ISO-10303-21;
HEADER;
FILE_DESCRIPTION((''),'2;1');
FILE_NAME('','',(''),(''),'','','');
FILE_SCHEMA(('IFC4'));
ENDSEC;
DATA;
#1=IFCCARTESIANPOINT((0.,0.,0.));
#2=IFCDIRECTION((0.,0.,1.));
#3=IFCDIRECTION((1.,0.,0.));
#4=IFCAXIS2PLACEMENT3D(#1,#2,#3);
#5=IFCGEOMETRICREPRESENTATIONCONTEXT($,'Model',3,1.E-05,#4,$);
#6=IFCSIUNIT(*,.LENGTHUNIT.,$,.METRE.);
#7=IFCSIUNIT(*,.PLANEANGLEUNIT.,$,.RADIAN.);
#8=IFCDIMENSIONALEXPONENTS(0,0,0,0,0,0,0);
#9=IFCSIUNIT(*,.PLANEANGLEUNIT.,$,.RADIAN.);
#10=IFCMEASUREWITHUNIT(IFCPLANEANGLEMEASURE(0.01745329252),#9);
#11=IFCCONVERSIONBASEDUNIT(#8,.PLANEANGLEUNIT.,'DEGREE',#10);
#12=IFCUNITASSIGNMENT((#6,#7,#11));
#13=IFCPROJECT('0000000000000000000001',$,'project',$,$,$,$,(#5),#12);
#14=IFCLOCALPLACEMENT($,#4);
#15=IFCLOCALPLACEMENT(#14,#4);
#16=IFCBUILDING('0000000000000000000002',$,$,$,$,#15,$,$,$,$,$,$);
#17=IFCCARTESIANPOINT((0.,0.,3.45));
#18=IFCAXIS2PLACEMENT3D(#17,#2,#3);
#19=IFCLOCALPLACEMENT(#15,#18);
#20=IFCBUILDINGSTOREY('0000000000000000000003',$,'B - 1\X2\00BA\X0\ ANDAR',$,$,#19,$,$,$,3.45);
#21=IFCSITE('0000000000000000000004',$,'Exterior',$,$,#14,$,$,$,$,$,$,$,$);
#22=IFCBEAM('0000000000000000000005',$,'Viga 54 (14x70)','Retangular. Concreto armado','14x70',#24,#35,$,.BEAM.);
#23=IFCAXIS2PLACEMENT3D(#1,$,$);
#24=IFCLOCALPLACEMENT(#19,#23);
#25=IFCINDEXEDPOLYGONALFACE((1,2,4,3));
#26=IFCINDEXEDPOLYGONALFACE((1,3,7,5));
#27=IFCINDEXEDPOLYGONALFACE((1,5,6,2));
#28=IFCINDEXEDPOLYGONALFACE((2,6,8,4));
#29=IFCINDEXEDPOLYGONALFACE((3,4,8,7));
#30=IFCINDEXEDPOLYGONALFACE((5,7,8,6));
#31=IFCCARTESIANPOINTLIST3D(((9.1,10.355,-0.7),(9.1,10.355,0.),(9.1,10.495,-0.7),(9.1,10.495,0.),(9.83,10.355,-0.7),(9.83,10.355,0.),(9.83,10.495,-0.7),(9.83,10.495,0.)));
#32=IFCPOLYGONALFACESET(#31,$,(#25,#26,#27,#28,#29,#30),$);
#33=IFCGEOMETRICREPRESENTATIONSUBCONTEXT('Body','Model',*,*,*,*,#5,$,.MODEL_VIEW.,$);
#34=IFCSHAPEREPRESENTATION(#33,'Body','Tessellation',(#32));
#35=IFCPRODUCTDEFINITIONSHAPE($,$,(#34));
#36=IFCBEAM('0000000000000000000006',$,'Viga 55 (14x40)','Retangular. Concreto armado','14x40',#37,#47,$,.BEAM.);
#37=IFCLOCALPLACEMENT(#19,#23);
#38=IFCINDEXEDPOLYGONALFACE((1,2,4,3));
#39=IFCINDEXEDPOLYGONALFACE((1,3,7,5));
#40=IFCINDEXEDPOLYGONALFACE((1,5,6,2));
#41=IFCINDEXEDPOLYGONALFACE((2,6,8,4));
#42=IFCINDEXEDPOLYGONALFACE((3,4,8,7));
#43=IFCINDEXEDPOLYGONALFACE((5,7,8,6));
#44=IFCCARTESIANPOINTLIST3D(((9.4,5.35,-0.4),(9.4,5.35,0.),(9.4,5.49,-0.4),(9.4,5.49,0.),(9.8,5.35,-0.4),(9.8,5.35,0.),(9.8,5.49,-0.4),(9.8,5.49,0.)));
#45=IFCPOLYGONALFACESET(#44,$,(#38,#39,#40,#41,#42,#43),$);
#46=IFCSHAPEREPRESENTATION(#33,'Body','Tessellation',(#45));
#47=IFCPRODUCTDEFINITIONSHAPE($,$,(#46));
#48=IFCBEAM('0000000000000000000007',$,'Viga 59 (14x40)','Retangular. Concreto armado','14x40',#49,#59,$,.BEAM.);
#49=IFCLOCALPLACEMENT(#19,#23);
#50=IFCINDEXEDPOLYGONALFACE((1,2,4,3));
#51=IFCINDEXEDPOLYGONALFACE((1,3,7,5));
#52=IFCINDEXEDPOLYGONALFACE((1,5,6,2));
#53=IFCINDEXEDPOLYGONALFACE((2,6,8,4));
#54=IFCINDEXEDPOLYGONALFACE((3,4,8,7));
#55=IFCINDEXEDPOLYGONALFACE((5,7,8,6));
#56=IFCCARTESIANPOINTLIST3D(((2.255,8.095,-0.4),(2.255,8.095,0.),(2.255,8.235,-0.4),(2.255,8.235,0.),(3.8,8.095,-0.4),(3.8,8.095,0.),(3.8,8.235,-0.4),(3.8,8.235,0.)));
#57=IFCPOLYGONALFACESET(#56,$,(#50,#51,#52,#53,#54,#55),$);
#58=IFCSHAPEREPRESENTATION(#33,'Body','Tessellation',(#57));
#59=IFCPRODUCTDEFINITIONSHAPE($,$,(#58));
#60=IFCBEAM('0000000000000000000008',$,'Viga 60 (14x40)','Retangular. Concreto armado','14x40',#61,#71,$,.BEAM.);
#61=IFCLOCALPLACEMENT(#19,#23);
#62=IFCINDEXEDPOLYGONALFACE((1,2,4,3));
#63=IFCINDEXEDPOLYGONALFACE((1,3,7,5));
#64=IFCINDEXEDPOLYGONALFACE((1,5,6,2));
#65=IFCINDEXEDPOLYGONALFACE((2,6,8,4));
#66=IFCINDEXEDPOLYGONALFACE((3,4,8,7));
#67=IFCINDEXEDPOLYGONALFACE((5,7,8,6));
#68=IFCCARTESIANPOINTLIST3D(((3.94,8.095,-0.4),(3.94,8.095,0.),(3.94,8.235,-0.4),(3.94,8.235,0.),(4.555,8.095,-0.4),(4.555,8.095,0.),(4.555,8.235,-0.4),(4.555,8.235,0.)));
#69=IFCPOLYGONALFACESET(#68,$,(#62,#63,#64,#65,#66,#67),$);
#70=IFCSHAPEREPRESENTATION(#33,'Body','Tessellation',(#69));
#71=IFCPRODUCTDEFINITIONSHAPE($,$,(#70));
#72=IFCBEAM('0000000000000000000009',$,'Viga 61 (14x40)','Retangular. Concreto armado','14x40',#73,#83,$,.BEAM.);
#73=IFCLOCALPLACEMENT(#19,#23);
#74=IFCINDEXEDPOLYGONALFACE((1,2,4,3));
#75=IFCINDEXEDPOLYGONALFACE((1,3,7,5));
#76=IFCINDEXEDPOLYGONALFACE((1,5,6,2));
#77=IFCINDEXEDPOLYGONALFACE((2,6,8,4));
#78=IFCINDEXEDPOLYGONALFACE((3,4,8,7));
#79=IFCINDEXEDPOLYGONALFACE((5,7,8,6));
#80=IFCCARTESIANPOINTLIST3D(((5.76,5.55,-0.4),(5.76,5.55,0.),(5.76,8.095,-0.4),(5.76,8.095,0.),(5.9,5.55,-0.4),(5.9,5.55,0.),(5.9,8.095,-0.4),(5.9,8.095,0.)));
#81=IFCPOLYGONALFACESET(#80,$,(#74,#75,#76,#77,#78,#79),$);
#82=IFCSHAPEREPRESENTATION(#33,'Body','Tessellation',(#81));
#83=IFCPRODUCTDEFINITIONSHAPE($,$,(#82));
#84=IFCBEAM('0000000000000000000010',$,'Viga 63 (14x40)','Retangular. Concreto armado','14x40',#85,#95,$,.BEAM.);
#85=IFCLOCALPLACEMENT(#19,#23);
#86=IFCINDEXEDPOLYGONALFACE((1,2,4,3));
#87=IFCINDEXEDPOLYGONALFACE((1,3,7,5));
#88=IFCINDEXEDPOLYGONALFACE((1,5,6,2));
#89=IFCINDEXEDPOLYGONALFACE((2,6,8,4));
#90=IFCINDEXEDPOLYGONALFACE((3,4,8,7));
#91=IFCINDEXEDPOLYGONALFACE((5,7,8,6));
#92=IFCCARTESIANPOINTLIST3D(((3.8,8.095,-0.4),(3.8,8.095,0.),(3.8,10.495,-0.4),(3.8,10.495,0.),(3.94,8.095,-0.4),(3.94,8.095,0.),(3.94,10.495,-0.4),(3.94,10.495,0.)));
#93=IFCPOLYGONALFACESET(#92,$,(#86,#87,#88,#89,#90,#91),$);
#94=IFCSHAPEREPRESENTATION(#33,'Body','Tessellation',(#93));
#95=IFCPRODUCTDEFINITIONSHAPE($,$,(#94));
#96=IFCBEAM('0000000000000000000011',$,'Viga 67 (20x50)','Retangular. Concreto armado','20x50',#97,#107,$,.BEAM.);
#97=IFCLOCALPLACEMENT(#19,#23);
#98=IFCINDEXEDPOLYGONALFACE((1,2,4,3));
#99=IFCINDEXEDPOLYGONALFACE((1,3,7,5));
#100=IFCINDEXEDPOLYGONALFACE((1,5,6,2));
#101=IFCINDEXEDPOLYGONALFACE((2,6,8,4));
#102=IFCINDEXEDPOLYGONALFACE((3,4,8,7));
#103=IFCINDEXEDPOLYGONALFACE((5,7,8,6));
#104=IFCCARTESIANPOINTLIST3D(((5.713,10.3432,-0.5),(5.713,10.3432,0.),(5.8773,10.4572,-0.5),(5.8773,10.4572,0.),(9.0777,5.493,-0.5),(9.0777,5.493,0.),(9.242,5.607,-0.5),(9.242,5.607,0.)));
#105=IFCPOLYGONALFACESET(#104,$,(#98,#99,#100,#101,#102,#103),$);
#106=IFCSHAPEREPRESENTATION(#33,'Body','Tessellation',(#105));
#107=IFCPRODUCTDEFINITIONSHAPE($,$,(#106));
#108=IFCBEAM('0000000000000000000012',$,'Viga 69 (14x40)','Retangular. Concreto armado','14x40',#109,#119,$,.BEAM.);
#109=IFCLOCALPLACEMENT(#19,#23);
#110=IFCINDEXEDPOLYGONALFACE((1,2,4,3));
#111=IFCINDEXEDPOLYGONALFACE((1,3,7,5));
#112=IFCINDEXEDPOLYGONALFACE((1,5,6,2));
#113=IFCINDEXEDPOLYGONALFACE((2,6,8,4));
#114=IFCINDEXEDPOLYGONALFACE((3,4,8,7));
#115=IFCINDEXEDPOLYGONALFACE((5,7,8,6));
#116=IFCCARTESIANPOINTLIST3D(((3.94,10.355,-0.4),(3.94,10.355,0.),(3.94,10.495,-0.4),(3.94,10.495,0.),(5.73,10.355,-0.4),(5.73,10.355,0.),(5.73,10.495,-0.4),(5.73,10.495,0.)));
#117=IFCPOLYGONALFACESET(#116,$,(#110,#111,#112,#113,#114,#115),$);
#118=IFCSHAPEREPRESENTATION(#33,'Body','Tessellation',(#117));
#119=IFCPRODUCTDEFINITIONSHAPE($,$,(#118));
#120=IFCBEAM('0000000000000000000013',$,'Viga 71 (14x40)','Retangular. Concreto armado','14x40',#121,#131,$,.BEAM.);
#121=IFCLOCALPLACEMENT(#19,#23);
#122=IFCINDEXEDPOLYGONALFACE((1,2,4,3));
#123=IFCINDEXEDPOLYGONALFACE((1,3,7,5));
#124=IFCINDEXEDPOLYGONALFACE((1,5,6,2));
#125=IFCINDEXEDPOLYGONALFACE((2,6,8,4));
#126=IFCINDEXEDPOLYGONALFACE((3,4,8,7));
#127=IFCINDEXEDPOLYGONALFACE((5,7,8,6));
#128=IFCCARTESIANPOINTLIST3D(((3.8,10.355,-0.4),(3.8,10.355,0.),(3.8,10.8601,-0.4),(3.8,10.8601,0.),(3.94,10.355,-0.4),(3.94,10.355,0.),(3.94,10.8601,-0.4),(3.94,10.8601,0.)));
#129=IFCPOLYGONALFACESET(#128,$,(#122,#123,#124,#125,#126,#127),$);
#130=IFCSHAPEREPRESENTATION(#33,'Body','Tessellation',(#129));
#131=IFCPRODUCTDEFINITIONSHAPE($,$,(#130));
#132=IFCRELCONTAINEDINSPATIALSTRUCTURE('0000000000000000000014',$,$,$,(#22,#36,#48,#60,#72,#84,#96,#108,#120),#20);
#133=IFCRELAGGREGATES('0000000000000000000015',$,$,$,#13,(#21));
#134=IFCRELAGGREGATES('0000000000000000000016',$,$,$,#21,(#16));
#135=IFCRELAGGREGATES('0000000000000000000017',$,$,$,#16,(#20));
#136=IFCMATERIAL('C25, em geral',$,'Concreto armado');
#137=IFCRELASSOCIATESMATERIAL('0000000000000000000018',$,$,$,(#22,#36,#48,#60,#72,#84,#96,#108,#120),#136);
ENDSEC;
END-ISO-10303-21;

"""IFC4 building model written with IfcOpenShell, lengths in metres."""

from ifc_helpers import new_model, entity, si_unit, converted_unit, frame, frame_2d, origin_with_axes, place, context, subcontext, project, spatial, rectangle, extrude, material, element, save


model = new_model("IFC4")

# Units and contexts
model_context = context("Model", 3, precision=1e-05, world=origin_with_axes())
body_context = subcontext(model_context, "Body", "Model", "MODEL_VIEW")
ifc_project = project(units=[si_unit("LENGTHUNIT", "METRE"), si_unit("PLANEANGLEUNIT", "RADIAN"), converted_unit("PLANEANGLEUNIT", "DEGREE", entity("IfcPlaneAngleMeasure", 0.01745329252), si_unit("PLANEANGLEUNIT", "RADIAN"), dimensions=[0, 0, 0, 0, 0, 0, 0])], contexts=[model_context])

# Site, building, storey
site_placement = place(None, origin_with_axes())
site = spatial("IfcSite", under=ifc_project, at=site_placement, Name="Exterior")
building_placement = place(site_placement, origin_with_axes())
building = spatial("IfcBuilding", under=site, at=building_placement)
storey_placement = place(building_placement, frame((0.0, 0.0, 3.45), z_axis=(0.0, 0.0, 1.0), x_axis=(1.0, 0.0, 0.0)))
storey = spatial("IfcBuildingStorey", under=building, at=storey_placement, Name="B - 1º ANDAR", Elevation=3.45)

# Shared definitions
ifc_material = material(Name="C25, em geral", Category="Concreto armado")

# Beams
beam_1_placement = place(storey_placement, frame((9.1, 10.425, 0.0), z_axis=(1.0, 0.0, 0.0), x_axis=(0.0, 1.0, 0.0)))
element("IfcBeam", 1, at=beam_1_placement, inside=storey, material=ifc_material, Name="Viga 54 (14x70)", Description="Retangular. Concreto armado", ObjectType="14x70", PredefinedType="BEAM", context=body_context, shape_type="SweptSolid", body=[
    extrude(rectangle(XDim=0.14, YDim=0.7, at=frame_2d((0.0, -0.35), x_axis=(1.0, 0.0))), origin_with_axes(), (0.0, 0.0, 1.0), 0.73),
])
beam_2_placement = place(storey_placement, frame((9.4, 5.42, 0.0), z_axis=(1.0, 0.0, 0.0), x_axis=(0.0, 1.0, 0.0)))
element("IfcBeam", 2, at=beam_2_placement, inside=storey, material=ifc_material, Name="Viga 55 (14x40)", Description="Retangular. Concreto armado", ObjectType="14x40", PredefinedType="BEAM", context=body_context, shape_type="SweptSolid", body=[
    extrude(rectangle(XDim=0.14, YDim=0.4, at=frame_2d((0.0, -0.2), x_axis=(1.0, 0.0))), origin_with_axes(), (0.0, 0.0, 1.0), 0.4),
])
beam_3_placement = place(storey_placement, frame((3.8, 8.165, 0.0), z_axis=(-1.0, 0.0, 0.0), x_axis=(0.0, -1.0, 0.0)))
element("IfcBeam", 3, at=beam_3_placement, inside=storey, material=ifc_material, Name="Viga 59 (14x40)", Description="Retangular. Concreto armado", ObjectType="14x40", PredefinedType="BEAM", context=body_context, shape_type="SweptSolid", body=[
    extrude(rectangle(XDim=0.14, YDim=0.4, at=frame_2d((0.0, -0.2), x_axis=(1.0, 0.0))), origin_with_axes(), (0.0, 0.0, 1.0), 1.545),
])
beam_4_placement = place(storey_placement, frame((4.555, 8.165, 0.0), z_axis=(-1.0, 0.0, 0.0), x_axis=(0.0, -1.0, 0.0)))
element("IfcBeam", 4, at=beam_4_placement, inside=storey, material=ifc_material, Name="Viga 60 (14x40)", Description="Retangular. Concreto armado", ObjectType="14x40", PredefinedType="BEAM", context=body_context, shape_type="SweptSolid", body=[
    extrude(rectangle(XDim=0.14, YDim=0.4, at=frame_2d((0.0, -0.2), x_axis=(1.0, 0.0))), origin_with_axes(), (0.0, 0.0, 1.0), 0.615),
])
beam_5_placement = place(storey_placement, frame((5.83, 8.095, 0.0), z_axis=(0.0, -1.0, 0.0), x_axis=(1.0, 0.0, 0.0)))
element("IfcBeam", 5, at=beam_5_placement, inside=storey, material=ifc_material, Name="Viga 61 (14x40)", Description="Retangular. Concreto armado", ObjectType="14x40", PredefinedType="BEAM", context=body_context, shape_type="SweptSolid", body=[
    extrude(rectangle(XDim=0.14, YDim=0.4, at=frame_2d((0.0, -0.2), x_axis=(1.0, 0.0))), origin_with_axes(), (0.0, 0.0, 1.0), 2.545),
])
beam_6_placement = place(storey_placement, frame((3.87, 8.095, 0.0), z_axis=(0.0, 1.0, 0.0), x_axis=(-1.0, 0.0, 0.0)))
element("IfcBeam", 6, at=beam_6_placement, inside=storey, material=ifc_material, Name="Viga 63 (14x40)", Description="Retangular. Concreto armado", ObjectType="14x40", PredefinedType="BEAM", context=body_context, shape_type="SweptSolid", body=[
    extrude(rectangle(XDim=0.14, YDim=0.4, at=frame_2d((0.0, -0.2), x_axis=(1.0, 0.0))), origin_with_axes(), (0.0, 0.0, 1.0), 2.4),
])
beam_7_placement = place(storey_placement, frame((9.1598, 5.55, 0.0), z_axis=(-0.56999, 0.821652, 0.0), x_axis=(-0.821652, -0.56999, 0.0)))
element("IfcBeam", 7, at=beam_7_placement, inside=storey, material=ifc_material, Name="Viga 67 (20x50)", Description="Retangular. Concreto armado", ObjectType="20x50", PredefinedType="BEAM", context=body_context, shape_type="SweptSolid", body=[
    extrude(rectangle(XDim=0.2, YDim=0.5, at=frame_2d((0.0, -0.25), x_axis=(1.0, 0.0))), origin_with_axes(), (0.0, 0.0, 1.0), 5.903),
])
beam_8_placement = place(storey_placement, frame((3.94, 10.425, 0.0), z_axis=(1.0, 0.0, 0.0), x_axis=(0.0, 1.0, 0.0)))
element("IfcBeam", 8, at=beam_8_placement, inside=storey, material=ifc_material, Name="Viga 69 (14x40)", Description="Retangular. Concreto armado", ObjectType="14x40", PredefinedType="BEAM", context=body_context, shape_type="SweptSolid", body=[
    extrude(rectangle(XDim=0.14, YDim=0.4, at=frame_2d((0.0, -0.2), x_axis=(1.0, 0.0))), origin_with_axes(), (0.0, 0.0, 1.0), 1.79),
])
beam_9_placement = place(storey_placement, frame((3.87, 10.355, 0.0), z_axis=(0.0, 1.0, 0.0), x_axis=(-1.0, 0.0, 0.0)))
element("IfcBeam", 9, at=beam_9_placement, inside=storey, material=ifc_material, Name="Viga 71 (14x40)", Description="Retangular. Concreto armado", ObjectType="14x40", PredefinedType="BEAM", context=body_context, shape_type="SweptSolid", body=[
    extrude(rectangle(XDim=0.14, YDim=0.4, at=frame_2d((0.0, -0.2), x_axis=(1.0, 0.0))), origin_with_axes(), (0.0, 0.0, 1.0), 0.5051),
])

save(model, "model.ifc")
